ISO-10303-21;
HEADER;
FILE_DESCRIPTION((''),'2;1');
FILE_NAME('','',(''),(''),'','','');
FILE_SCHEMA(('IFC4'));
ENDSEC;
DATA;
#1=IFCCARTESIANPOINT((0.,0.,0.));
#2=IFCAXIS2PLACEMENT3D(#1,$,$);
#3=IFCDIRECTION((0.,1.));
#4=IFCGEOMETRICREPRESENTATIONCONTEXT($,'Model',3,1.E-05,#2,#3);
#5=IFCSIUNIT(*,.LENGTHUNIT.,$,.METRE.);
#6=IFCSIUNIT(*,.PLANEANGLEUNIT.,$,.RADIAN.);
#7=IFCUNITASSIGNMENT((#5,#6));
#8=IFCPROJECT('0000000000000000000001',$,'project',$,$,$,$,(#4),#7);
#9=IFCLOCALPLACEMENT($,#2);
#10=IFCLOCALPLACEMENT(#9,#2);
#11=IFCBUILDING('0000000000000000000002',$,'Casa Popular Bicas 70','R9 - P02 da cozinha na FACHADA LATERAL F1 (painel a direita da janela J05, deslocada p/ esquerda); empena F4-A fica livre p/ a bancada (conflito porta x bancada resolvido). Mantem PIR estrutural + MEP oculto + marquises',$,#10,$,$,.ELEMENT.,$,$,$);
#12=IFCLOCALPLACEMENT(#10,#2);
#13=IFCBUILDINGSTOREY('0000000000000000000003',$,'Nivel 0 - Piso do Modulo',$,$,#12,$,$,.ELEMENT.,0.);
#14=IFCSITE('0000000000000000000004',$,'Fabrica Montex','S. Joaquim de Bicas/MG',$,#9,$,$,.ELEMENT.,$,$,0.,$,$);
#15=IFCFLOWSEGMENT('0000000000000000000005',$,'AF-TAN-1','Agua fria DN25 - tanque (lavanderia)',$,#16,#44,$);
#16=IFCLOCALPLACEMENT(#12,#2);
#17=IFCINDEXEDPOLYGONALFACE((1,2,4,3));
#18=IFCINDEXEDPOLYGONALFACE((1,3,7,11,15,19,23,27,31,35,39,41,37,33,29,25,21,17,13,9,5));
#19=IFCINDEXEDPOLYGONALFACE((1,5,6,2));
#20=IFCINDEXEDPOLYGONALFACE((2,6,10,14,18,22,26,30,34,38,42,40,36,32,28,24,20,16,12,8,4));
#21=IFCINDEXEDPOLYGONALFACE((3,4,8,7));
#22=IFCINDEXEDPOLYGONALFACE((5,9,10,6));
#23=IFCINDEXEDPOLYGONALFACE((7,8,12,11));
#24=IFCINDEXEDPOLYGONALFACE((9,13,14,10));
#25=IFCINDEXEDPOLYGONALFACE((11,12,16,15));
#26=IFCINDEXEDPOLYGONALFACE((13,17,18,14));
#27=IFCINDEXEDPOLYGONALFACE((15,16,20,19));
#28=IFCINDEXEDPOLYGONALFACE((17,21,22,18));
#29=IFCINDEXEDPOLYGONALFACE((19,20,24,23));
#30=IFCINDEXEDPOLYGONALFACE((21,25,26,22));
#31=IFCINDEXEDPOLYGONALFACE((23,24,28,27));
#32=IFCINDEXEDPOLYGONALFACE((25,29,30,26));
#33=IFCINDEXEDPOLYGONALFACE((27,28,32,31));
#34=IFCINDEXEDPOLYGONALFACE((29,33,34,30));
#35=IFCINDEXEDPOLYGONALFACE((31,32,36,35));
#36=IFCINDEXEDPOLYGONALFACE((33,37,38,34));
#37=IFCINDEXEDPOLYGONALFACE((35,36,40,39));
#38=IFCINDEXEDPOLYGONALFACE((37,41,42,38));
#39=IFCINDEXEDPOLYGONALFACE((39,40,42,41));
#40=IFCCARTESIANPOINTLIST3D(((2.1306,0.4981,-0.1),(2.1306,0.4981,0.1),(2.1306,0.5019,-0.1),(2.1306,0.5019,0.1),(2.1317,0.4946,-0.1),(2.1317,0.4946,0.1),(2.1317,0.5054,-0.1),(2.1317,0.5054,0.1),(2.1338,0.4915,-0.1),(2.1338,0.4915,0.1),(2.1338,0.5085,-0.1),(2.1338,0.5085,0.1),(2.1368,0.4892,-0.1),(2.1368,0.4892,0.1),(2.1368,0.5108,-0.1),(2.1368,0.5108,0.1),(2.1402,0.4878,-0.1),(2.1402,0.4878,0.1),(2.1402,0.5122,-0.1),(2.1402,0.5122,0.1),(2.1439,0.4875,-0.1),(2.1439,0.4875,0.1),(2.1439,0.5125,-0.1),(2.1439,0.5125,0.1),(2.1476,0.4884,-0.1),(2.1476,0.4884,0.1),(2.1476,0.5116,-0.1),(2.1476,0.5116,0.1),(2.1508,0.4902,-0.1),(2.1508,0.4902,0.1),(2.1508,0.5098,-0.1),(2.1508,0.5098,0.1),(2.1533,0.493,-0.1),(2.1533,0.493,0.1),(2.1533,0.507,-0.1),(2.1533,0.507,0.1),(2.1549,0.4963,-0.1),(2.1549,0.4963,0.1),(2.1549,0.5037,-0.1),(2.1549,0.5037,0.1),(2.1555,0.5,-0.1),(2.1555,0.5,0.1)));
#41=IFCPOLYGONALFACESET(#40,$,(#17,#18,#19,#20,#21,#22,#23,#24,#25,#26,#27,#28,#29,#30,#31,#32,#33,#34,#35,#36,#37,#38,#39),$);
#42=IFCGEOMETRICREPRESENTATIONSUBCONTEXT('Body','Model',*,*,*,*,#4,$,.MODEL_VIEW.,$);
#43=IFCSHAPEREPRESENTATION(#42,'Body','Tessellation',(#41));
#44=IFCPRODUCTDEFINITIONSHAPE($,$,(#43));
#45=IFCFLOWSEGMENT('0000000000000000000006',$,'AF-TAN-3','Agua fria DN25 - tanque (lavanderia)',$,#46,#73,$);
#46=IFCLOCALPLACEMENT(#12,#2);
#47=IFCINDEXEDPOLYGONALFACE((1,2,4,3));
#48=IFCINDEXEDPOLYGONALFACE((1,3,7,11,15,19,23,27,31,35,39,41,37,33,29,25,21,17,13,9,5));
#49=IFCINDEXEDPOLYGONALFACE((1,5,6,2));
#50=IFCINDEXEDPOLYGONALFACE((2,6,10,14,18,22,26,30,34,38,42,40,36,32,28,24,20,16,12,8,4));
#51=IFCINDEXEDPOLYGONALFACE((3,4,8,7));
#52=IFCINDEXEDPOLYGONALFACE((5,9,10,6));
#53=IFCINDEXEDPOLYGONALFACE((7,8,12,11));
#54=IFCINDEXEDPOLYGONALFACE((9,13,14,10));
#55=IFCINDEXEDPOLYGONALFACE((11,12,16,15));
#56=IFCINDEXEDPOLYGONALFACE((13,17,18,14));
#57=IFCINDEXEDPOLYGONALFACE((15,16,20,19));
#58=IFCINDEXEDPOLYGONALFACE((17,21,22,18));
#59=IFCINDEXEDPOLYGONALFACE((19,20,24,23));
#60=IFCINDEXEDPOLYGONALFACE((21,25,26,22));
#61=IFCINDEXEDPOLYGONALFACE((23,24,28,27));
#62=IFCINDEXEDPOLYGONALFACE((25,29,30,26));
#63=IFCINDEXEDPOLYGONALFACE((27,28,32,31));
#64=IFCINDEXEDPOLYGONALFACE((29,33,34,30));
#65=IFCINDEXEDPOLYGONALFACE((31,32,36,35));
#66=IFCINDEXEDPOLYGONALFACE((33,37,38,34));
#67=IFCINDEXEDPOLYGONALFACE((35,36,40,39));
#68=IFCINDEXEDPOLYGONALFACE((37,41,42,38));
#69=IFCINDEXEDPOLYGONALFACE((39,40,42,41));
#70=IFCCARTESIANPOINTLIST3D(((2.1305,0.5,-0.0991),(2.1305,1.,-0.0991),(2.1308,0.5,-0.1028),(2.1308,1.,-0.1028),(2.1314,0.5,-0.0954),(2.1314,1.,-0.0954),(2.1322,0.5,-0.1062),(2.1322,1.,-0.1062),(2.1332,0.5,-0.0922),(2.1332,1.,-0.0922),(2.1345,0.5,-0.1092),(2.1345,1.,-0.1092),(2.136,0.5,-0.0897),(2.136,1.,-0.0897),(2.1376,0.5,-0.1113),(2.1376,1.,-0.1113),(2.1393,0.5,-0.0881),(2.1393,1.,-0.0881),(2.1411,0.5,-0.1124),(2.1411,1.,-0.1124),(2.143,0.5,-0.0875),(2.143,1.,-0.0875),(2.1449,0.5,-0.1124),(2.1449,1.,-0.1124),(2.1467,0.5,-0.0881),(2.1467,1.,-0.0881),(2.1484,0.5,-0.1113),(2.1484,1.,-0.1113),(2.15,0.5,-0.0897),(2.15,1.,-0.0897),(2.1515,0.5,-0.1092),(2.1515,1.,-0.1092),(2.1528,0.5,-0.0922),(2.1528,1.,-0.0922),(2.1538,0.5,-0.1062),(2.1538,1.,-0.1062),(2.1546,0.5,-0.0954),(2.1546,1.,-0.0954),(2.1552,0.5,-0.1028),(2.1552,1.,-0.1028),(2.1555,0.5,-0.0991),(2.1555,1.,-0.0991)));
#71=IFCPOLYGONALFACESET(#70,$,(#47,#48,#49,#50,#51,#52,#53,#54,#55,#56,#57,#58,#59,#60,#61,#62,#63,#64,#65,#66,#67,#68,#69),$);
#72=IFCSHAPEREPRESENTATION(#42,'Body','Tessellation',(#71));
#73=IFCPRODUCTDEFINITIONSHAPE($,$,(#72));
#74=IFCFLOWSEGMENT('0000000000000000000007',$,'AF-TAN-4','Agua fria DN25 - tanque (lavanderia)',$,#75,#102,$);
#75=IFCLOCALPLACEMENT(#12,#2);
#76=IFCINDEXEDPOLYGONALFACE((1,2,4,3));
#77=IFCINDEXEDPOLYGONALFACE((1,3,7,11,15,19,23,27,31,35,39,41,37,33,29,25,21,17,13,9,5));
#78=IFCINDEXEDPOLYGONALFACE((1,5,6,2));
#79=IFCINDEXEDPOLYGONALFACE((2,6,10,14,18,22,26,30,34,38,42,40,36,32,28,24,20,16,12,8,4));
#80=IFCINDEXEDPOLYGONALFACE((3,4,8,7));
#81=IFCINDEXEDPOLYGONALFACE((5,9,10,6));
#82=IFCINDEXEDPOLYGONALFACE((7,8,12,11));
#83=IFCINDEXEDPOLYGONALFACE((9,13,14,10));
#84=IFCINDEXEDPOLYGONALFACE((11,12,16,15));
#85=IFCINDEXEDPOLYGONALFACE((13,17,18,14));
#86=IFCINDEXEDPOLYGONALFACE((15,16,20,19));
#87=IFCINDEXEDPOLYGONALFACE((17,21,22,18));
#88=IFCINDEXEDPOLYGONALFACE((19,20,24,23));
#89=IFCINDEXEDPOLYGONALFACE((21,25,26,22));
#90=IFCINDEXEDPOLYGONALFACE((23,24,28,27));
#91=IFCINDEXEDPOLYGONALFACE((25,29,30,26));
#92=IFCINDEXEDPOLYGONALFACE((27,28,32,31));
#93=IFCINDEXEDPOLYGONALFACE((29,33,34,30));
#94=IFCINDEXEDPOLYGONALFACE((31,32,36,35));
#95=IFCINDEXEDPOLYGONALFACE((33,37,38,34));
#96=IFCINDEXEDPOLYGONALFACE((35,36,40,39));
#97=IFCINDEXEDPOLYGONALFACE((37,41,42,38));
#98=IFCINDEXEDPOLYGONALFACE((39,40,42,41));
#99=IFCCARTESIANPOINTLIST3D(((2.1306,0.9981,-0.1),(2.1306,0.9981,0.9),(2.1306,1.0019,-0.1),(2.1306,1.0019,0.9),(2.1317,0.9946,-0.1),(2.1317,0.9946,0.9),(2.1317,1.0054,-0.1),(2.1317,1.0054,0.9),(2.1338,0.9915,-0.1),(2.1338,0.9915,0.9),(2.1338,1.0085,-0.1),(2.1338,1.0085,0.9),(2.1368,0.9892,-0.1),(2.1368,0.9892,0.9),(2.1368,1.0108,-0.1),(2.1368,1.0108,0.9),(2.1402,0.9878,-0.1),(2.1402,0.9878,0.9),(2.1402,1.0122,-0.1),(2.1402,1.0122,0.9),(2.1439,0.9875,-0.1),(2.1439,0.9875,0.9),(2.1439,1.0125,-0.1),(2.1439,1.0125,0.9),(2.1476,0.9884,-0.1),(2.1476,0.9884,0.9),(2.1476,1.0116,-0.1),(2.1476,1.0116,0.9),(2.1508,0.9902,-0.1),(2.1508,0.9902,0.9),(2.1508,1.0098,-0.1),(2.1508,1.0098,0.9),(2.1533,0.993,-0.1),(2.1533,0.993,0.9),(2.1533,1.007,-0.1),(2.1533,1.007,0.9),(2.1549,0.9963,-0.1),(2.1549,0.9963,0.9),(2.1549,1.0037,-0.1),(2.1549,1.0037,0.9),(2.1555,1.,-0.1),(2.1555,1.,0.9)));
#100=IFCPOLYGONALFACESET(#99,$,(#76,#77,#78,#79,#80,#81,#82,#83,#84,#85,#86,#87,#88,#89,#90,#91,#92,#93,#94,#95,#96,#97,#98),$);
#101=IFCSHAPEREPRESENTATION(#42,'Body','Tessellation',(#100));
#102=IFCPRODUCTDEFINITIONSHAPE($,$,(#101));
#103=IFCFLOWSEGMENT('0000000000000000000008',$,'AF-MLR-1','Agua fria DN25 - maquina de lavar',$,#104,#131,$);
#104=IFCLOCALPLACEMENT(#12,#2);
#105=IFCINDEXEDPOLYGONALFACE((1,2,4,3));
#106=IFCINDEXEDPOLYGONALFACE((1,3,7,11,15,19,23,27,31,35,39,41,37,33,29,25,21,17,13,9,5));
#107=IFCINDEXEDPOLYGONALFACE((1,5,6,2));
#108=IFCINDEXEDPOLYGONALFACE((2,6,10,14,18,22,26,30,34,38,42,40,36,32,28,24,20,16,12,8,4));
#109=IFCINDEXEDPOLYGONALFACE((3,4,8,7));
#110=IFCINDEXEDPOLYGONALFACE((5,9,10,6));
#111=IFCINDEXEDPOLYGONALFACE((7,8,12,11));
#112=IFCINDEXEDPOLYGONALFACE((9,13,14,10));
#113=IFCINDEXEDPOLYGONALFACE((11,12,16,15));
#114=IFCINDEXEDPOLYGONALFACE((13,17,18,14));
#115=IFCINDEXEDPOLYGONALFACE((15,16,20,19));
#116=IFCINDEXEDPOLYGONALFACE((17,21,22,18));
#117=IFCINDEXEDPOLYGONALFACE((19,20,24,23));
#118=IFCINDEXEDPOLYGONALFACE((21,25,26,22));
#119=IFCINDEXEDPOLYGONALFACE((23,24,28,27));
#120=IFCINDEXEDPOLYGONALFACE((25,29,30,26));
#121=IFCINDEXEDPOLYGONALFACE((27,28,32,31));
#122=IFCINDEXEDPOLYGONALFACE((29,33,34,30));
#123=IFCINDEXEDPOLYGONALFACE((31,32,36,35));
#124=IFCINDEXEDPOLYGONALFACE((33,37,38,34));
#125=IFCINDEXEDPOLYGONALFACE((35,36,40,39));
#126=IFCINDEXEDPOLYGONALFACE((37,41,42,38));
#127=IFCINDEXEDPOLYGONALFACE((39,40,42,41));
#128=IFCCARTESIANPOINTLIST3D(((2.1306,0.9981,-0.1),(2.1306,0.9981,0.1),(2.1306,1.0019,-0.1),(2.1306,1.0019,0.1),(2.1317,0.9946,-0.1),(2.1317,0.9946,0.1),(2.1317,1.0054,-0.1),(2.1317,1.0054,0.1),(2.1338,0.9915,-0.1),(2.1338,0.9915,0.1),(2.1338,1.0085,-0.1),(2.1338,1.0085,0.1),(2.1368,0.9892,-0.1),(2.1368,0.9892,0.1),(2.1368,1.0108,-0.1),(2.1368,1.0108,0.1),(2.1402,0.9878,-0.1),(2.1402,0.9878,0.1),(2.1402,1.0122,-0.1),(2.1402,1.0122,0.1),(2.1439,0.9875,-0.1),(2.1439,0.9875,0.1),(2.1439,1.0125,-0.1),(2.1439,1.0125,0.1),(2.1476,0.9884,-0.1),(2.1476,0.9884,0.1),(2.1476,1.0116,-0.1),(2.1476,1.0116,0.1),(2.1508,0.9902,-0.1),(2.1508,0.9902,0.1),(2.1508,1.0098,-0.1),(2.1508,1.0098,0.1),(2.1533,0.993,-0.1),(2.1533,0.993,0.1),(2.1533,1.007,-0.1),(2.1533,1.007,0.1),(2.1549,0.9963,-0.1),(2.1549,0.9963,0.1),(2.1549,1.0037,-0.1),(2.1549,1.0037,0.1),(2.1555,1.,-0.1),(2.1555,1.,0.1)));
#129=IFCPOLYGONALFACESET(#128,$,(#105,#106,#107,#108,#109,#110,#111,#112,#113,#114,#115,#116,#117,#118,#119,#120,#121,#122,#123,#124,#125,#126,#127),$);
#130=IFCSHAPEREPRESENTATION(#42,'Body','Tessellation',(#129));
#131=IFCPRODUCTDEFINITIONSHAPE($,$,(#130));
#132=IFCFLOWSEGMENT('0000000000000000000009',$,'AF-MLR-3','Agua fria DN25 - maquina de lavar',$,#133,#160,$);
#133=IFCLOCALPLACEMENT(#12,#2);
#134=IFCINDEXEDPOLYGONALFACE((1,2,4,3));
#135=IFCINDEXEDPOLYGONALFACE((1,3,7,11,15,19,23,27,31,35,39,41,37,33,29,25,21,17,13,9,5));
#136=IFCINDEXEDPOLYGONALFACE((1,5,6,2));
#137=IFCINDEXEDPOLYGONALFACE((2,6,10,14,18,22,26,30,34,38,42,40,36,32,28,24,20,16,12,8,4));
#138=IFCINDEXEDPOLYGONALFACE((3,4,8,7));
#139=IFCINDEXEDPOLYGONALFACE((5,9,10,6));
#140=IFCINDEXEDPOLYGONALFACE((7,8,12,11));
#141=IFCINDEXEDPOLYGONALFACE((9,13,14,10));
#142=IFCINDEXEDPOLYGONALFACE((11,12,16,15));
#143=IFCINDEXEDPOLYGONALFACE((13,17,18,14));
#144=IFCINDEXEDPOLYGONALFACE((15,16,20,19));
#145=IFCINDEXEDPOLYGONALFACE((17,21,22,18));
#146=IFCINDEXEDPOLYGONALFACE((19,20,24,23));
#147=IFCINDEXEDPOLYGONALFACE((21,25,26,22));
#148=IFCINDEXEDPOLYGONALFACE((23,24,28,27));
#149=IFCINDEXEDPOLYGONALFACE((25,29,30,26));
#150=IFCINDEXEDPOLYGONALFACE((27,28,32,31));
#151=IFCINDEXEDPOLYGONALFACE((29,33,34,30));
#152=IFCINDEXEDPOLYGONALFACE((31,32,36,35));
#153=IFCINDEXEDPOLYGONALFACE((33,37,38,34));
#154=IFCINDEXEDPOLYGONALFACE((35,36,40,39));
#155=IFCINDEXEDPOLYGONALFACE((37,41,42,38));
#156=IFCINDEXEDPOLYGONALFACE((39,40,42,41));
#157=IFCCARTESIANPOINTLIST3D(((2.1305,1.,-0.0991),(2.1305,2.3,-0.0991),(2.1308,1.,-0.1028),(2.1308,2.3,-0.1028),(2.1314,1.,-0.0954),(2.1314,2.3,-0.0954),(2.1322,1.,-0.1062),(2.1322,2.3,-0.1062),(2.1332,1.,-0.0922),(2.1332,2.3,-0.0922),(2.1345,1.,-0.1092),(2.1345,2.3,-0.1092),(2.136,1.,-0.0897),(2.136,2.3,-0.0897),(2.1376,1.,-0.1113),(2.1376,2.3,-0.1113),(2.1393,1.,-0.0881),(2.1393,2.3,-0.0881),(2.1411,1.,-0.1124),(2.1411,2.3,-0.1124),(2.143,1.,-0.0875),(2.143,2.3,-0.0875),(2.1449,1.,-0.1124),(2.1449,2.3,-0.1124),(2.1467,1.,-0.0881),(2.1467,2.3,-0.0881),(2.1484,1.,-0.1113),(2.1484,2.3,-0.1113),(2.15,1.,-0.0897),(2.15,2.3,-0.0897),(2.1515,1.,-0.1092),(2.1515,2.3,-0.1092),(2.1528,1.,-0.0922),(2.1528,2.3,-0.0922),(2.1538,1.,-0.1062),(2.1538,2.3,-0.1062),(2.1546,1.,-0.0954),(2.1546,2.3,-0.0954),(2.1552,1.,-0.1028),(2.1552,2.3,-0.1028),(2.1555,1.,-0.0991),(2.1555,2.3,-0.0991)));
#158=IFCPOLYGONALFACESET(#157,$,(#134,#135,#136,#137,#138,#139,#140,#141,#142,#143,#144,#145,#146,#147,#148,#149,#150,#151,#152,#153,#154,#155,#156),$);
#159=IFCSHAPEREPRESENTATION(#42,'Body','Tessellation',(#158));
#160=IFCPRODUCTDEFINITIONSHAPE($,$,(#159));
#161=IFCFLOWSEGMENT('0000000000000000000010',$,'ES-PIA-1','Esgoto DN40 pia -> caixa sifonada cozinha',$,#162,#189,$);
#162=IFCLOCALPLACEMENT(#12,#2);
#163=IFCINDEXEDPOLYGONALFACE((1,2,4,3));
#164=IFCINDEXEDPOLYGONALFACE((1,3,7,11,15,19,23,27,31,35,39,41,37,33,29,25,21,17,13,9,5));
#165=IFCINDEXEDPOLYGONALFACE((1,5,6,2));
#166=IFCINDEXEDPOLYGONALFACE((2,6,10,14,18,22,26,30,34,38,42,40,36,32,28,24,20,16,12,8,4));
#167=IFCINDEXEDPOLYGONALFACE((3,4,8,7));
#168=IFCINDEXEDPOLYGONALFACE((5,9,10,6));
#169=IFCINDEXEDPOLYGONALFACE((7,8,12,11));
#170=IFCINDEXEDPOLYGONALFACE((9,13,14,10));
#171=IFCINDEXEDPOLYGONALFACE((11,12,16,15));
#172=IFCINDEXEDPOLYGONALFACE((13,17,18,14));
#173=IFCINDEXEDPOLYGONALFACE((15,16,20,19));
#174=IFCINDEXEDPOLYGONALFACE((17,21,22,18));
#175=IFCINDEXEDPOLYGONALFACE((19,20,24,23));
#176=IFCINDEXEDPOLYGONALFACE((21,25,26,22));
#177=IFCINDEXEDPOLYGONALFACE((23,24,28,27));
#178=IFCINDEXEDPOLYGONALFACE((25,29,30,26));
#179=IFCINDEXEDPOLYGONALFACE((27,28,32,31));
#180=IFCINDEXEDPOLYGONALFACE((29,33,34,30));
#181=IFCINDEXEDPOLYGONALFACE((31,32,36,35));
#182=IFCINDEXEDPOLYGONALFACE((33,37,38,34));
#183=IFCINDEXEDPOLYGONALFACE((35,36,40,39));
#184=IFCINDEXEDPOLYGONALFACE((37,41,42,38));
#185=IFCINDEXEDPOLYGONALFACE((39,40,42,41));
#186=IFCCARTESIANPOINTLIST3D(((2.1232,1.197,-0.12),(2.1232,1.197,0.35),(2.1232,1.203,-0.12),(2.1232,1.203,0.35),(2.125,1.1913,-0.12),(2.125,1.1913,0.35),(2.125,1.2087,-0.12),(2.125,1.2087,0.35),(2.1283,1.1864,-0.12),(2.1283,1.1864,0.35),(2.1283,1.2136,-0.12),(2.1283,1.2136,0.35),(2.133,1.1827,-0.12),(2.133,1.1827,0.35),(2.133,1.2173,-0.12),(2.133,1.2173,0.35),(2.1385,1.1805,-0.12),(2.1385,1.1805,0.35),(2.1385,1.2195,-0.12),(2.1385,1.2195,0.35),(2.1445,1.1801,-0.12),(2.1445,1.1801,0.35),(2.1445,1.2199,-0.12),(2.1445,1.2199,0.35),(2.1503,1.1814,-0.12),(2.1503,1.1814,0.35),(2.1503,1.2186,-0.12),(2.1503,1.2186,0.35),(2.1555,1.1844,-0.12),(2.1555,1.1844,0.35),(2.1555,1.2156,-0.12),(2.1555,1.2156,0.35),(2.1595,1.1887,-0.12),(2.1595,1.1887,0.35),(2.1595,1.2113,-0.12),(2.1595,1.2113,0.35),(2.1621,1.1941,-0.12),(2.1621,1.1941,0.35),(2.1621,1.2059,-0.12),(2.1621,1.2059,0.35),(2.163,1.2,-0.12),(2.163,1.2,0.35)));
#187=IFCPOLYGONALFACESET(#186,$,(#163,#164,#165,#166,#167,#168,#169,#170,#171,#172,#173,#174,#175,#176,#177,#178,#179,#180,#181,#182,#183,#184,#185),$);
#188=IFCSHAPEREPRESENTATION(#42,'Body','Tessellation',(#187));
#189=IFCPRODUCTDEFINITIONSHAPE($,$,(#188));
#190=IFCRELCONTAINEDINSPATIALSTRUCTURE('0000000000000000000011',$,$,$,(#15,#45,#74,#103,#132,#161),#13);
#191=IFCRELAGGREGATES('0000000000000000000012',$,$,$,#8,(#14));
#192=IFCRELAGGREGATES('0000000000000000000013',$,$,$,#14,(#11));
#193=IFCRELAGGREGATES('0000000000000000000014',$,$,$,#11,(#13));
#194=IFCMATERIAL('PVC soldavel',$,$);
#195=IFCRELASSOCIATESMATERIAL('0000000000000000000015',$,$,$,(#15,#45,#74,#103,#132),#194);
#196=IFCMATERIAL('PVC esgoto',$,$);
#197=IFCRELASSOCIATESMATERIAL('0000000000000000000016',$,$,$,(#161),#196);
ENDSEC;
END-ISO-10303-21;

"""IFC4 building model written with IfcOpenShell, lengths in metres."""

from ifc_helpers import new_model, si_unit, direction, frame, origin, origin_2d, place, context, subcontext, project, spatial, circle, extrude, material, element, save


model = new_model("IFC4")

# Units and contexts
model_context = context("Model", 3, precision=1e-05, world=origin(), true_north=direction((0.0, 1.0)))
body_context = subcontext(model_context, "Body", "Model", "MODEL_VIEW")
ifc_project = project(units=[si_unit("LENGTHUNIT", "METRE"), si_unit("PLANEANGLEUNIT", "RADIAN")], contexts=[model_context])

# Site, building, storey
site_placement = place(None, origin())
site = spatial("IfcSite", under=ifc_project, at=site_placement, Name="Fabrica Montex", Description="S. Joaquim de Bicas/MG", CompositionType="ELEMENT", RefElevation=0.0)
building_placement = place(site_placement, origin())
building = spatial("IfcBuilding", under=site, at=building_placement, Name="Casa Popular Bicas 70", Description="R9 - P02 da cozinha na FACHADA LATERAL F1 (painel a direita da janela J05, deslocada p/ esquerda); empena F4-A fica livre p/ a bancada (conflito porta x bancada resolvido). Mantem PIR estrutural + MEP oculto + marquises", CompositionType="ELEMENT")
storey_placement = place(building_placement, origin())
storey = spatial("IfcBuildingStorey", under=building, at=storey_placement, Name="Nivel 0 - Piso do Modulo", CompositionType="ELEMENT", Elevation=0.0)

# Flow segments
ifc_material_1 = material(Name="PVC soldavel")
flow_segment_1_placement = place(storey_placement, frame((2.143, 0.5, 0.1), z_axis=(0.0, 0.0, -1.0), x_axis=(1.0, 0.0, 0.0)))
element("IfcFlowSegment", 1, at=flow_segment_1_placement, inside=storey, material=ifc_material_1, Name="AF-TAN-1", Description="Agua fria DN25 - tanque (lavanderia)", context=body_context, shape_type="SweptSolid", body=[
    extrude(circle(Radius=0.0125, at=origin_2d()), origin(), (0.0, 0.0, 1.0), 0.2),
])
flow_segment_2_placement = place(storey_placement, frame((2.143, 0.5, -0.1), z_axis=(0.0, 1.0, 0.0), x_axis=(0.0, 0.0, 1.0)))
element("IfcFlowSegment", 2, at=flow_segment_2_placement, inside=storey, material=ifc_material_1, Name="AF-TAN-3", Description="Agua fria DN25 - tanque (lavanderia)", context=body_context, shape_type="SweptSolid", body=[
    extrude(circle(Radius=0.0125, at=origin_2d()), origin(), (0.0, 0.0, 1.0), 0.5),
])
flow_segment_3_placement = place(storey_placement, frame((2.143, 1.0, -0.1), z_axis=(0.0, 0.0, 1.0), x_axis=(1.0, 0.0, 0.0)))
element("IfcFlowSegment", 3, at=flow_segment_3_placement, inside=storey, material=ifc_material_1, Name="AF-TAN-4", Description="Agua fria DN25 - tanque (lavanderia)", context=body_context, shape_type="SweptSolid", body=[
    extrude(circle(Radius=0.0125, at=origin_2d()), origin(), (0.0, 0.0, 1.0), 1.0),
])
flow_segment_4_placement = place(storey_placement, frame((2.143, 1.0, 0.1), z_axis=(0.0, 0.0, -1.0), x_axis=(1.0, 0.0, 0.0)))
element("IfcFlowSegment", 4, at=flow_segment_4_placement, inside=storey, material=ifc_material_1, Name="AF-MLR-1", Description="Agua fria DN25 - maquina de lavar", context=body_context, shape_type="SweptSolid", body=[
    extrude(circle(Radius=0.0125, at=origin_2d()), origin(), (0.0, 0.0, 1.0), 0.2),
])
flow_segment_5_placement = place(storey_placement, frame((2.143, 1.0, -0.1), z_axis=(0.0, 1.0, 0.0), x_axis=(0.0, 0.0, 1.0)))
element("IfcFlowSegment", 5, at=flow_segment_5_placement, inside=storey, material=ifc_material_1, Name="AF-MLR-3", Description="Agua fria DN25 - maquina de lavar", context=body_context, shape_type="SweptSolid", body=[
    extrude(circle(Radius=0.0125, at=origin_2d()), origin(), (0.0, 0.0, 1.0), 1.3),
])
ifc_material_2 = material(Name="PVC esgoto")
flow_segment_6_placement = place(storey_placement, frame((2.143, 1.2, 0.35), z_axis=(0.0, 0.0, -1.0), x_axis=(1.0, 0.0, 0.0)))
element("IfcFlowSegment", 6, at=flow_segment_6_placement, inside=storey, material=ifc_material_2, Name="ES-PIA-1", Description="Esgoto DN40 pia -> caixa sifonada cozinha", context=body_context, shape_type="SweptSolid", body=[
    extrude(circle(Radius=0.02, at=origin_2d()), origin(), (0.0, 0.0, 1.0), 0.47),
])

save(model, "model.ifc")
